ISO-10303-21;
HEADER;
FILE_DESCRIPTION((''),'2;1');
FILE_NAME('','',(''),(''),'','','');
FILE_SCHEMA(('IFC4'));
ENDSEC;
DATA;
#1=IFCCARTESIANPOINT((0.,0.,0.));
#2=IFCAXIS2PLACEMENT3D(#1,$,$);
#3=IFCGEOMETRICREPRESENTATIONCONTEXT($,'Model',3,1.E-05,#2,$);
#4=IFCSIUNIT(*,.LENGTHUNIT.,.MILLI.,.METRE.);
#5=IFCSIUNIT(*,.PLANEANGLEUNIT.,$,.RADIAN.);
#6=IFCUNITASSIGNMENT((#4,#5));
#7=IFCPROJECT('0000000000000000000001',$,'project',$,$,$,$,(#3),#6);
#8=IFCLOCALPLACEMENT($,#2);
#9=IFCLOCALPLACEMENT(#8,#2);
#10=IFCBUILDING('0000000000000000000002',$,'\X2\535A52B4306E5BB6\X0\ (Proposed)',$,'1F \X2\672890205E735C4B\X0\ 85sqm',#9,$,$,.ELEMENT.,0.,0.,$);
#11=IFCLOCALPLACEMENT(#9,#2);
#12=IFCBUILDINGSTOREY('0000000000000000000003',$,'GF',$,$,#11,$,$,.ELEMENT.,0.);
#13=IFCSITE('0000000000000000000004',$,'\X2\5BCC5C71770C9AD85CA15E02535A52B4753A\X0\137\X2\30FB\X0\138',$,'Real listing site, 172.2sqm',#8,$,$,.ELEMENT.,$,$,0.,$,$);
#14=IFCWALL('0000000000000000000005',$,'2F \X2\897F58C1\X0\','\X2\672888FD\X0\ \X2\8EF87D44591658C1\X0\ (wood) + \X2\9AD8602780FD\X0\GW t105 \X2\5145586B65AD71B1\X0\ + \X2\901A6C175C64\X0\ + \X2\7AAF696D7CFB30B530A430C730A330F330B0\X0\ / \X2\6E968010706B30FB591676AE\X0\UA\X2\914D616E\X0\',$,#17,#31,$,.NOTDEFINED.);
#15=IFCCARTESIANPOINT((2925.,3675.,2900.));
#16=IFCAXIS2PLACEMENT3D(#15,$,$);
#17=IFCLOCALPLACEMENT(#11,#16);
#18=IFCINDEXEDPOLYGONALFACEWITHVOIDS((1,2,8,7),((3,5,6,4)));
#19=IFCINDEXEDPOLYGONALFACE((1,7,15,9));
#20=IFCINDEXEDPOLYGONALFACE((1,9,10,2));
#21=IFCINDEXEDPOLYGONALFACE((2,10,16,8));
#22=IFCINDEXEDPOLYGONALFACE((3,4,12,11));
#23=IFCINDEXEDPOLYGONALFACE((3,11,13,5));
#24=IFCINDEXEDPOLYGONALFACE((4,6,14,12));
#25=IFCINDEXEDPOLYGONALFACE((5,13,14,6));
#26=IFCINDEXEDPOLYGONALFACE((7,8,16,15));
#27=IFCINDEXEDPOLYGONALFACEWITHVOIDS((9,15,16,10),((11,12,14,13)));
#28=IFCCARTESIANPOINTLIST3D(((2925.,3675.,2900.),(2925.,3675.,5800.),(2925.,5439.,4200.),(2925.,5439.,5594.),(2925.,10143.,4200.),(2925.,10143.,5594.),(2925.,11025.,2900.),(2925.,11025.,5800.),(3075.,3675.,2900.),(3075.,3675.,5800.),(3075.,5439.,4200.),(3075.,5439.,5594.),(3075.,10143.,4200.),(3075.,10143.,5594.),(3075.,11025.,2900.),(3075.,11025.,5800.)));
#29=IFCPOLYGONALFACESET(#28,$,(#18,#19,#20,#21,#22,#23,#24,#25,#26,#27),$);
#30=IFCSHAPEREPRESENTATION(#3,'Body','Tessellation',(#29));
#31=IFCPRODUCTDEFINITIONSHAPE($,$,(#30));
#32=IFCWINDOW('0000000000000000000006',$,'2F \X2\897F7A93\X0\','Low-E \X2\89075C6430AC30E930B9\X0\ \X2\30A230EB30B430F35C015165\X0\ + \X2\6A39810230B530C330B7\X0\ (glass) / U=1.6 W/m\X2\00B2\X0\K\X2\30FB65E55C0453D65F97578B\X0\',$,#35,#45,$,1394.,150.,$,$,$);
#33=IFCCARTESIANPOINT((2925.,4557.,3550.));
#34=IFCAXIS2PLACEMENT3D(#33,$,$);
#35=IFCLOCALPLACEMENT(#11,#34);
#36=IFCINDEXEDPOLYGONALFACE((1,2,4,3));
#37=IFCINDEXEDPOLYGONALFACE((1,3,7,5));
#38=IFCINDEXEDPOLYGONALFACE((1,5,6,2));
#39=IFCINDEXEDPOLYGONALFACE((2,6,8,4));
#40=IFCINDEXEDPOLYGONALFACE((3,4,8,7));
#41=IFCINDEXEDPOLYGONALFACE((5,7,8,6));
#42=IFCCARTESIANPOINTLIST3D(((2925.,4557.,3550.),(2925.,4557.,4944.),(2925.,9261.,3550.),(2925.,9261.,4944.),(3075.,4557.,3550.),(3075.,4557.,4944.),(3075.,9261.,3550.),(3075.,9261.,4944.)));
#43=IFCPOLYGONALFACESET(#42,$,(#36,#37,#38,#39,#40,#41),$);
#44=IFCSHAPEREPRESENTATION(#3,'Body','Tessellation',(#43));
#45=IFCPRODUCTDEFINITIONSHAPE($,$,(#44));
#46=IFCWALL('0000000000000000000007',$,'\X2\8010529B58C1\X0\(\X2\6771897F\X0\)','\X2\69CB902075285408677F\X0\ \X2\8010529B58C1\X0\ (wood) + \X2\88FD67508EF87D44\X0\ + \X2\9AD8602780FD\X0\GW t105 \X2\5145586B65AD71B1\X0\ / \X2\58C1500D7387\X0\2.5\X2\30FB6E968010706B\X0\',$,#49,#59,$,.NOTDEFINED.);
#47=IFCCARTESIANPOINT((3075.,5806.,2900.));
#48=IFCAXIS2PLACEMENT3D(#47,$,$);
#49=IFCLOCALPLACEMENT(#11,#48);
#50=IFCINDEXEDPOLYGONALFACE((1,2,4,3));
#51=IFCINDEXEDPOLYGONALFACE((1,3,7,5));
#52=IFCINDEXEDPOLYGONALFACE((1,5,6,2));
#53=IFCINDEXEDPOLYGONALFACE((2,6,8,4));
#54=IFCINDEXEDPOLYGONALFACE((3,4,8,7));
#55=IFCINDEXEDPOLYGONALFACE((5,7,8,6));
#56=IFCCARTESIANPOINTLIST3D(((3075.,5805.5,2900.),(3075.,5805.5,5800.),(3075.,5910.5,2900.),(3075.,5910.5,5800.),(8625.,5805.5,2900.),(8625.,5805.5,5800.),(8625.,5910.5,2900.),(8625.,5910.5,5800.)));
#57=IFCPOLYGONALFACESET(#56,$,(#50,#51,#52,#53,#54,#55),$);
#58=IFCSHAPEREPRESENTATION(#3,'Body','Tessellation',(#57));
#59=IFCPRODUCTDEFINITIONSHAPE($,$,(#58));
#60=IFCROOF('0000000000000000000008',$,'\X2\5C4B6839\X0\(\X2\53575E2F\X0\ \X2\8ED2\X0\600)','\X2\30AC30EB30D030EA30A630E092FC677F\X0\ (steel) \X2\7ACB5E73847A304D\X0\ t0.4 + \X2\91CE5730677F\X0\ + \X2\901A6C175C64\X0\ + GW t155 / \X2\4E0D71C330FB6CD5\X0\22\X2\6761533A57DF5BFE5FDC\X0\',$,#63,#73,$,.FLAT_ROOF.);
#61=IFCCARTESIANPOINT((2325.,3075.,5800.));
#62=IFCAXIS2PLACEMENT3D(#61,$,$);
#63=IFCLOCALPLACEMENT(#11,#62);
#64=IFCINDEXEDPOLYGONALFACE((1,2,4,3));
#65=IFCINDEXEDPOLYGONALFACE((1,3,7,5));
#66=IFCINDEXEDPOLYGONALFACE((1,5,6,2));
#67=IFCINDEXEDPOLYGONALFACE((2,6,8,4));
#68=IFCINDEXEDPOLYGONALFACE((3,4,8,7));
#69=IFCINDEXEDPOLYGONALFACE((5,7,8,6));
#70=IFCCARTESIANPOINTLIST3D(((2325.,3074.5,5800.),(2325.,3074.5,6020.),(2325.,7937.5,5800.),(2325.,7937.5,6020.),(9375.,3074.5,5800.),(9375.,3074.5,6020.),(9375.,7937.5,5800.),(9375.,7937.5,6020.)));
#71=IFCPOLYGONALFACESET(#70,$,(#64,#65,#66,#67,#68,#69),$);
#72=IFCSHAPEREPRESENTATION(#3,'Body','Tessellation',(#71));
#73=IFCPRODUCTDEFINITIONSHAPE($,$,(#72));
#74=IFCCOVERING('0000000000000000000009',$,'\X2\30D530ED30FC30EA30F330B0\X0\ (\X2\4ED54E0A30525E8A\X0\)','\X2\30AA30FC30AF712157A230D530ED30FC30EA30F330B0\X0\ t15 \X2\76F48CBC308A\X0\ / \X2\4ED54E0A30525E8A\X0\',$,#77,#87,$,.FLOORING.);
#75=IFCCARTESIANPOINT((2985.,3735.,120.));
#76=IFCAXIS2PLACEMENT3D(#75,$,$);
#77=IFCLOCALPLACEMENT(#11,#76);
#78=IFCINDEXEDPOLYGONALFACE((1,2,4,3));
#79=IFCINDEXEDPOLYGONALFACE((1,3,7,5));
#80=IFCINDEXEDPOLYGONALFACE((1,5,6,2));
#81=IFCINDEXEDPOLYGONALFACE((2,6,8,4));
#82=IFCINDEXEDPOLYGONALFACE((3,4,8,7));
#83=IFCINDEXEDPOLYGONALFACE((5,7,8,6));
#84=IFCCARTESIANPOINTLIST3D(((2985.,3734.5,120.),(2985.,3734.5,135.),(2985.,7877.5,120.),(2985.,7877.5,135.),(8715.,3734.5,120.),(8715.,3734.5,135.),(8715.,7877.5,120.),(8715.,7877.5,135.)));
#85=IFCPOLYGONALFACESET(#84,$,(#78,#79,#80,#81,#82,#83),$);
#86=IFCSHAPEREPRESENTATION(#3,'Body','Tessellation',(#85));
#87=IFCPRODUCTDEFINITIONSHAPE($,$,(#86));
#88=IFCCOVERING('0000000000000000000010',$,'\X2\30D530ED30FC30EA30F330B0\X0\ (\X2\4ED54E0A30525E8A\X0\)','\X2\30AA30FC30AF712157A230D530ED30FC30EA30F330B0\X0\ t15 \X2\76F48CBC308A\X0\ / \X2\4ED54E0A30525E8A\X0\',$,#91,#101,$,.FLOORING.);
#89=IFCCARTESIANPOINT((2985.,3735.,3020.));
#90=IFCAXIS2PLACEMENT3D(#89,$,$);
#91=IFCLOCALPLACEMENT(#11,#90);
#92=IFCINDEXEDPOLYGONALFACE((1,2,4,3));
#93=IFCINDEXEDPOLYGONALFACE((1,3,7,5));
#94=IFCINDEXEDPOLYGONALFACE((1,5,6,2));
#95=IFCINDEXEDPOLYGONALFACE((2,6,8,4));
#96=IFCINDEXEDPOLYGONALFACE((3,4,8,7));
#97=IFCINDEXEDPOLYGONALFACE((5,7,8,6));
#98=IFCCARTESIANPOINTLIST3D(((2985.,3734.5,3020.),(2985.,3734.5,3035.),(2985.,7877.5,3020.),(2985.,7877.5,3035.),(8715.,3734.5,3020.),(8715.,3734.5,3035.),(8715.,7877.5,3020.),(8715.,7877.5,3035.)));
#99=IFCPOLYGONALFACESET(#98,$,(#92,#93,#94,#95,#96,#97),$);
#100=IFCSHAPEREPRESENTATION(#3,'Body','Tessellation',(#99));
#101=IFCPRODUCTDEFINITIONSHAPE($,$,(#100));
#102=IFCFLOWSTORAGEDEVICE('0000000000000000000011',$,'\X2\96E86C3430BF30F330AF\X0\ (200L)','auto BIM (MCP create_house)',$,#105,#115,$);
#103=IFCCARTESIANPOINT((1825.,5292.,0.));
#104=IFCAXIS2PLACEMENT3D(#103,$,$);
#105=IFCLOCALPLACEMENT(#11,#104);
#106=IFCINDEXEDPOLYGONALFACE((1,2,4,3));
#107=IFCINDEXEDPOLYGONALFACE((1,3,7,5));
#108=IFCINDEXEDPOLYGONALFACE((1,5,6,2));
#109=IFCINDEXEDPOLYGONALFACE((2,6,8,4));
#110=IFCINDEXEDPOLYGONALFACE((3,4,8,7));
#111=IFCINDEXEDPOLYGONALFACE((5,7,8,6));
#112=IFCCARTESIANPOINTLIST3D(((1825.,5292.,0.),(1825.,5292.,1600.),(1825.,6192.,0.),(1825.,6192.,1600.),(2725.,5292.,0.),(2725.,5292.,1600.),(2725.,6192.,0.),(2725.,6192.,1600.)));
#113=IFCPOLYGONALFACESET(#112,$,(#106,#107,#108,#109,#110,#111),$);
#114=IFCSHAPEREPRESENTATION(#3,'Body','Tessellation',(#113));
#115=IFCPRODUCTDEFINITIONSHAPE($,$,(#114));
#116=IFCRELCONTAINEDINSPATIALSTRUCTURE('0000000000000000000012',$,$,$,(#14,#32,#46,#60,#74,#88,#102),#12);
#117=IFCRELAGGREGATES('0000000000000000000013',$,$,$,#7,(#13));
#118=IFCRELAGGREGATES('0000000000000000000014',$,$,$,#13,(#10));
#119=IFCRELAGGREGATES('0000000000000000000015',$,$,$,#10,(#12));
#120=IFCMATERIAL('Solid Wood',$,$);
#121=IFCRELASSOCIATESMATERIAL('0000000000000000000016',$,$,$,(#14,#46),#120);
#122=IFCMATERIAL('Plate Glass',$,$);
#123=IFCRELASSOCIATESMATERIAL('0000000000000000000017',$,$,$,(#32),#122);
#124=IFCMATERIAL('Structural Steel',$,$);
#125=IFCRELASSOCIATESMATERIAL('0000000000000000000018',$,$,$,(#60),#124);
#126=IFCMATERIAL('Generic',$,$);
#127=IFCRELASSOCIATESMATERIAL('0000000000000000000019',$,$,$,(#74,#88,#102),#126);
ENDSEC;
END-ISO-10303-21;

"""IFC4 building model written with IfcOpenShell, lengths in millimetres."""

from ifc_helpers import new_model, si_unit, frame, frame_2d, origin, place, context, project, spatial, rectangle, extrude, material, element, fill, save


model = new_model("IFC4")

# Units and contexts
model_context = context("Model", 3, precision=1e-05, world=origin())
ifc_project = project(units=[si_unit("LENGTHUNIT", "METRE", prefix="MILLI"), si_unit("PLANEANGLEUNIT", "RADIAN")], contexts=[model_context])

# Site, building, storey
site_placement = place(None, origin())
site = spatial("IfcSite", under=ifc_project, at=site_placement, Name="富山県高岡市博労町137・138", ObjectType="Real listing site, 172.2sqm", CompositionType="ELEMENT", RefElevation=0.0)
building_placement = place(site_placement, origin())
building = spatial("IfcBuilding", under=site, at=building_placement, Name="博労の家 (Proposed)", ObjectType="1F 木造平屋 85sqm", CompositionType="ELEMENT", ElevationOfRefHeight=0.0, ElevationOfTerrain=0.0)
storey_placement = place(building_placement, origin())
storey = spatial("IfcBuildingStorey", under=building, at=storey_placement, Name="GF", CompositionType="ELEMENT", Elevation=0.0)

# Shared definitions
ifc_material_1 = material(Name="Solid Wood")
ifc_material_2 = material(Name="Generic")

# Shared definitions
ifc_material_3 = material(Name="Plate Glass")

# Wall, opening, window
wall_1_placement = place(storey_placement, frame((2925.0, 3675.0, 2900.0)))
wall_1 = element("IfcWall", 1, at=wall_1_placement, inside=storey, material=ifc_material_1, Name="2F 西壁", Description="木製 軸組外壁 (wood) + 高性能GW t105 充填断熱 + 通気層 + 窯業系サイディング / 準耐火・外皮UA配慮", PredefinedType="NOTDEFINED", context=model_context, shape_type="SweptSolid", body=[
    extrude(rectangle(XDim=150.0, YDim=7350.0, at=frame_2d((75.0, 3675.0))), frame((2925.0, 3675.0, 2900.0)), (0.0, 0.0, 1.0), 2900.0),
])
opening_1_placement = place(storey_placement, frame((2925.0, 4557.0, 3550.0)))
opening_1 = element("IfcOpeningElement", 2, at=opening_1_placement, cuts=wall_1, PredefinedType="NOTDEFINED", context=model_context, shape_type="SweptSolid", body=[
    extrude(rectangle(XDim=150.0, YDim=4704.0, at=frame_2d((75.0, 2352.0))), frame((2925.0, 4557.0, 3550.0)), (0.0, 0.0, 1.0), 1394.0),
])
window_1_placement = place(storey_placement, frame((2925.0, 4557.0, 3550.0)))
window_1 = element("IfcWindow", 3, at=window_1_placement, inside=storey, material=ifc_material_3, Name="2F 西窓", Description="Low-E 複層ガラス アルゴン封入 + 樹脂サッシ (glass) / U=1.6 W/m²K・日射取得型", OverallHeight=1394.0, OverallWidth=150.0, context=model_context, shape_type="SweptSolid", body=[
    extrude(rectangle(XDim=150.0, YDim=4704.0, at=frame_2d((75.0, 2352.0))), frame((2925.0, 4557.0, 3550.0)), (0.0, 0.0, 1.0), 1394.0),
])
fill(opening_1, window_1)

# Wall
wall_2_placement = place(storey_placement, frame((3075.0, 5806.0, 2900.0)))
element("IfcWall", 4, at=wall_2_placement, inside=storey, material=ifc_material_1, Name="耐力壁(東西)", Description="構造用合板 耐力壁 (wood) + 製材軸組 + 高性能GW t105 充填断熱 / 壁倍率2.5・準耐火", PredefinedType="NOTDEFINED", context=model_context, shape_type="SweptSolid", body=[
    extrude(rectangle(XDim=5550.0, YDim=105.0, at=frame_2d((2775.0, 52.0))), frame((3075.0, 5806.0, 2900.0)), (0.0, 0.0, 1.0), 2900.0),
])

# Roof
ifc_material_4 = material(Name="Structural Steel")
for number, where, name in (
    (5, (2325.0, 3075.0, 5800.0), "屋根(南帯 軒600)"),
):
    element("IfcRoof", number, at=place(storey_placement, frame(where)), inside=storey, material=ifc_material_4, Name=name, Description="ガルバリウム鋼板 (steel) 立平葺き t0.4 + 野地板 + 通気層 + GW t155 / 不燃・法22条区域対応", PredefinedType="FLAT_ROOF", context=model_context, shape_type="SweptSolid", body=[
        extrude(rectangle(XDim=7050.0, YDim=4863.0, at=frame_2d((3525.0, 2431.0))), frame((2325.0, 3075.0, 5800.0)), (0.0, 0.0, 1.0), 220.0),
    ])

# Coverings
covering_1_placement = place(storey_placement, frame((2985.0, 3735.0, 120.0)))
element("IfcCovering", 6, at=covering_1_placement, inside=storey, material=ifc_material_2, Name="フローリング (仕上げ床)", Description="オーク無垢フローリング t15 直貼り / 仕上げ床", PredefinedType="FLOORING", context=model_context, shape_type="SweptSolid", body=[
    extrude(rectangle(XDim=5730.0, YDim=4143.0, at=frame_2d((2865.0, 2071.0))), frame((2985.0, 3735.0, 120.0)), (0.0, 0.0, 1.0), 15.0),
])
covering_2_placement = place(storey_placement, frame((2985.0, 3735.0, 3020.0)))
element("IfcCovering", 7, at=covering_2_placement, inside=storey, material=ifc_material_2, Name="フローリング (仕上げ床)", Description="オーク無垢フローリング t15 直貼り / 仕上げ床", PredefinedType="FLOORING", context=model_context, shape_type="SweptSolid", body=[
    extrude(rectangle(XDim=5730.0, YDim=4143.0, at=frame_2d((2865.0, 2071.0))), frame((2985.0, 3735.0, 3020.0)), (0.0, 0.0, 1.0), 15.0),
])

# Flow storage device
flow_storage_device_placement = place(storey_placement, frame((1825.0, 5292.0, 0.0)))
element("IfcFlowStorageDevice", 8, at=flow_storage_device_placement, inside=storey, material=ifc_material_2, Name="雨水タンク (200L)", Description="auto BIM (MCP create_house)", context=model_context, shape_type="SweptSolid", body=[
    extrude(rectangle(XDim=900.0, YDim=900.0, at=frame_2d((450.0, 450.0))), frame((1825.0, 5292.0, 0.0)), (0.0, 0.0, 1.0), 1600.0),
])

save(model, "model.ifc")
